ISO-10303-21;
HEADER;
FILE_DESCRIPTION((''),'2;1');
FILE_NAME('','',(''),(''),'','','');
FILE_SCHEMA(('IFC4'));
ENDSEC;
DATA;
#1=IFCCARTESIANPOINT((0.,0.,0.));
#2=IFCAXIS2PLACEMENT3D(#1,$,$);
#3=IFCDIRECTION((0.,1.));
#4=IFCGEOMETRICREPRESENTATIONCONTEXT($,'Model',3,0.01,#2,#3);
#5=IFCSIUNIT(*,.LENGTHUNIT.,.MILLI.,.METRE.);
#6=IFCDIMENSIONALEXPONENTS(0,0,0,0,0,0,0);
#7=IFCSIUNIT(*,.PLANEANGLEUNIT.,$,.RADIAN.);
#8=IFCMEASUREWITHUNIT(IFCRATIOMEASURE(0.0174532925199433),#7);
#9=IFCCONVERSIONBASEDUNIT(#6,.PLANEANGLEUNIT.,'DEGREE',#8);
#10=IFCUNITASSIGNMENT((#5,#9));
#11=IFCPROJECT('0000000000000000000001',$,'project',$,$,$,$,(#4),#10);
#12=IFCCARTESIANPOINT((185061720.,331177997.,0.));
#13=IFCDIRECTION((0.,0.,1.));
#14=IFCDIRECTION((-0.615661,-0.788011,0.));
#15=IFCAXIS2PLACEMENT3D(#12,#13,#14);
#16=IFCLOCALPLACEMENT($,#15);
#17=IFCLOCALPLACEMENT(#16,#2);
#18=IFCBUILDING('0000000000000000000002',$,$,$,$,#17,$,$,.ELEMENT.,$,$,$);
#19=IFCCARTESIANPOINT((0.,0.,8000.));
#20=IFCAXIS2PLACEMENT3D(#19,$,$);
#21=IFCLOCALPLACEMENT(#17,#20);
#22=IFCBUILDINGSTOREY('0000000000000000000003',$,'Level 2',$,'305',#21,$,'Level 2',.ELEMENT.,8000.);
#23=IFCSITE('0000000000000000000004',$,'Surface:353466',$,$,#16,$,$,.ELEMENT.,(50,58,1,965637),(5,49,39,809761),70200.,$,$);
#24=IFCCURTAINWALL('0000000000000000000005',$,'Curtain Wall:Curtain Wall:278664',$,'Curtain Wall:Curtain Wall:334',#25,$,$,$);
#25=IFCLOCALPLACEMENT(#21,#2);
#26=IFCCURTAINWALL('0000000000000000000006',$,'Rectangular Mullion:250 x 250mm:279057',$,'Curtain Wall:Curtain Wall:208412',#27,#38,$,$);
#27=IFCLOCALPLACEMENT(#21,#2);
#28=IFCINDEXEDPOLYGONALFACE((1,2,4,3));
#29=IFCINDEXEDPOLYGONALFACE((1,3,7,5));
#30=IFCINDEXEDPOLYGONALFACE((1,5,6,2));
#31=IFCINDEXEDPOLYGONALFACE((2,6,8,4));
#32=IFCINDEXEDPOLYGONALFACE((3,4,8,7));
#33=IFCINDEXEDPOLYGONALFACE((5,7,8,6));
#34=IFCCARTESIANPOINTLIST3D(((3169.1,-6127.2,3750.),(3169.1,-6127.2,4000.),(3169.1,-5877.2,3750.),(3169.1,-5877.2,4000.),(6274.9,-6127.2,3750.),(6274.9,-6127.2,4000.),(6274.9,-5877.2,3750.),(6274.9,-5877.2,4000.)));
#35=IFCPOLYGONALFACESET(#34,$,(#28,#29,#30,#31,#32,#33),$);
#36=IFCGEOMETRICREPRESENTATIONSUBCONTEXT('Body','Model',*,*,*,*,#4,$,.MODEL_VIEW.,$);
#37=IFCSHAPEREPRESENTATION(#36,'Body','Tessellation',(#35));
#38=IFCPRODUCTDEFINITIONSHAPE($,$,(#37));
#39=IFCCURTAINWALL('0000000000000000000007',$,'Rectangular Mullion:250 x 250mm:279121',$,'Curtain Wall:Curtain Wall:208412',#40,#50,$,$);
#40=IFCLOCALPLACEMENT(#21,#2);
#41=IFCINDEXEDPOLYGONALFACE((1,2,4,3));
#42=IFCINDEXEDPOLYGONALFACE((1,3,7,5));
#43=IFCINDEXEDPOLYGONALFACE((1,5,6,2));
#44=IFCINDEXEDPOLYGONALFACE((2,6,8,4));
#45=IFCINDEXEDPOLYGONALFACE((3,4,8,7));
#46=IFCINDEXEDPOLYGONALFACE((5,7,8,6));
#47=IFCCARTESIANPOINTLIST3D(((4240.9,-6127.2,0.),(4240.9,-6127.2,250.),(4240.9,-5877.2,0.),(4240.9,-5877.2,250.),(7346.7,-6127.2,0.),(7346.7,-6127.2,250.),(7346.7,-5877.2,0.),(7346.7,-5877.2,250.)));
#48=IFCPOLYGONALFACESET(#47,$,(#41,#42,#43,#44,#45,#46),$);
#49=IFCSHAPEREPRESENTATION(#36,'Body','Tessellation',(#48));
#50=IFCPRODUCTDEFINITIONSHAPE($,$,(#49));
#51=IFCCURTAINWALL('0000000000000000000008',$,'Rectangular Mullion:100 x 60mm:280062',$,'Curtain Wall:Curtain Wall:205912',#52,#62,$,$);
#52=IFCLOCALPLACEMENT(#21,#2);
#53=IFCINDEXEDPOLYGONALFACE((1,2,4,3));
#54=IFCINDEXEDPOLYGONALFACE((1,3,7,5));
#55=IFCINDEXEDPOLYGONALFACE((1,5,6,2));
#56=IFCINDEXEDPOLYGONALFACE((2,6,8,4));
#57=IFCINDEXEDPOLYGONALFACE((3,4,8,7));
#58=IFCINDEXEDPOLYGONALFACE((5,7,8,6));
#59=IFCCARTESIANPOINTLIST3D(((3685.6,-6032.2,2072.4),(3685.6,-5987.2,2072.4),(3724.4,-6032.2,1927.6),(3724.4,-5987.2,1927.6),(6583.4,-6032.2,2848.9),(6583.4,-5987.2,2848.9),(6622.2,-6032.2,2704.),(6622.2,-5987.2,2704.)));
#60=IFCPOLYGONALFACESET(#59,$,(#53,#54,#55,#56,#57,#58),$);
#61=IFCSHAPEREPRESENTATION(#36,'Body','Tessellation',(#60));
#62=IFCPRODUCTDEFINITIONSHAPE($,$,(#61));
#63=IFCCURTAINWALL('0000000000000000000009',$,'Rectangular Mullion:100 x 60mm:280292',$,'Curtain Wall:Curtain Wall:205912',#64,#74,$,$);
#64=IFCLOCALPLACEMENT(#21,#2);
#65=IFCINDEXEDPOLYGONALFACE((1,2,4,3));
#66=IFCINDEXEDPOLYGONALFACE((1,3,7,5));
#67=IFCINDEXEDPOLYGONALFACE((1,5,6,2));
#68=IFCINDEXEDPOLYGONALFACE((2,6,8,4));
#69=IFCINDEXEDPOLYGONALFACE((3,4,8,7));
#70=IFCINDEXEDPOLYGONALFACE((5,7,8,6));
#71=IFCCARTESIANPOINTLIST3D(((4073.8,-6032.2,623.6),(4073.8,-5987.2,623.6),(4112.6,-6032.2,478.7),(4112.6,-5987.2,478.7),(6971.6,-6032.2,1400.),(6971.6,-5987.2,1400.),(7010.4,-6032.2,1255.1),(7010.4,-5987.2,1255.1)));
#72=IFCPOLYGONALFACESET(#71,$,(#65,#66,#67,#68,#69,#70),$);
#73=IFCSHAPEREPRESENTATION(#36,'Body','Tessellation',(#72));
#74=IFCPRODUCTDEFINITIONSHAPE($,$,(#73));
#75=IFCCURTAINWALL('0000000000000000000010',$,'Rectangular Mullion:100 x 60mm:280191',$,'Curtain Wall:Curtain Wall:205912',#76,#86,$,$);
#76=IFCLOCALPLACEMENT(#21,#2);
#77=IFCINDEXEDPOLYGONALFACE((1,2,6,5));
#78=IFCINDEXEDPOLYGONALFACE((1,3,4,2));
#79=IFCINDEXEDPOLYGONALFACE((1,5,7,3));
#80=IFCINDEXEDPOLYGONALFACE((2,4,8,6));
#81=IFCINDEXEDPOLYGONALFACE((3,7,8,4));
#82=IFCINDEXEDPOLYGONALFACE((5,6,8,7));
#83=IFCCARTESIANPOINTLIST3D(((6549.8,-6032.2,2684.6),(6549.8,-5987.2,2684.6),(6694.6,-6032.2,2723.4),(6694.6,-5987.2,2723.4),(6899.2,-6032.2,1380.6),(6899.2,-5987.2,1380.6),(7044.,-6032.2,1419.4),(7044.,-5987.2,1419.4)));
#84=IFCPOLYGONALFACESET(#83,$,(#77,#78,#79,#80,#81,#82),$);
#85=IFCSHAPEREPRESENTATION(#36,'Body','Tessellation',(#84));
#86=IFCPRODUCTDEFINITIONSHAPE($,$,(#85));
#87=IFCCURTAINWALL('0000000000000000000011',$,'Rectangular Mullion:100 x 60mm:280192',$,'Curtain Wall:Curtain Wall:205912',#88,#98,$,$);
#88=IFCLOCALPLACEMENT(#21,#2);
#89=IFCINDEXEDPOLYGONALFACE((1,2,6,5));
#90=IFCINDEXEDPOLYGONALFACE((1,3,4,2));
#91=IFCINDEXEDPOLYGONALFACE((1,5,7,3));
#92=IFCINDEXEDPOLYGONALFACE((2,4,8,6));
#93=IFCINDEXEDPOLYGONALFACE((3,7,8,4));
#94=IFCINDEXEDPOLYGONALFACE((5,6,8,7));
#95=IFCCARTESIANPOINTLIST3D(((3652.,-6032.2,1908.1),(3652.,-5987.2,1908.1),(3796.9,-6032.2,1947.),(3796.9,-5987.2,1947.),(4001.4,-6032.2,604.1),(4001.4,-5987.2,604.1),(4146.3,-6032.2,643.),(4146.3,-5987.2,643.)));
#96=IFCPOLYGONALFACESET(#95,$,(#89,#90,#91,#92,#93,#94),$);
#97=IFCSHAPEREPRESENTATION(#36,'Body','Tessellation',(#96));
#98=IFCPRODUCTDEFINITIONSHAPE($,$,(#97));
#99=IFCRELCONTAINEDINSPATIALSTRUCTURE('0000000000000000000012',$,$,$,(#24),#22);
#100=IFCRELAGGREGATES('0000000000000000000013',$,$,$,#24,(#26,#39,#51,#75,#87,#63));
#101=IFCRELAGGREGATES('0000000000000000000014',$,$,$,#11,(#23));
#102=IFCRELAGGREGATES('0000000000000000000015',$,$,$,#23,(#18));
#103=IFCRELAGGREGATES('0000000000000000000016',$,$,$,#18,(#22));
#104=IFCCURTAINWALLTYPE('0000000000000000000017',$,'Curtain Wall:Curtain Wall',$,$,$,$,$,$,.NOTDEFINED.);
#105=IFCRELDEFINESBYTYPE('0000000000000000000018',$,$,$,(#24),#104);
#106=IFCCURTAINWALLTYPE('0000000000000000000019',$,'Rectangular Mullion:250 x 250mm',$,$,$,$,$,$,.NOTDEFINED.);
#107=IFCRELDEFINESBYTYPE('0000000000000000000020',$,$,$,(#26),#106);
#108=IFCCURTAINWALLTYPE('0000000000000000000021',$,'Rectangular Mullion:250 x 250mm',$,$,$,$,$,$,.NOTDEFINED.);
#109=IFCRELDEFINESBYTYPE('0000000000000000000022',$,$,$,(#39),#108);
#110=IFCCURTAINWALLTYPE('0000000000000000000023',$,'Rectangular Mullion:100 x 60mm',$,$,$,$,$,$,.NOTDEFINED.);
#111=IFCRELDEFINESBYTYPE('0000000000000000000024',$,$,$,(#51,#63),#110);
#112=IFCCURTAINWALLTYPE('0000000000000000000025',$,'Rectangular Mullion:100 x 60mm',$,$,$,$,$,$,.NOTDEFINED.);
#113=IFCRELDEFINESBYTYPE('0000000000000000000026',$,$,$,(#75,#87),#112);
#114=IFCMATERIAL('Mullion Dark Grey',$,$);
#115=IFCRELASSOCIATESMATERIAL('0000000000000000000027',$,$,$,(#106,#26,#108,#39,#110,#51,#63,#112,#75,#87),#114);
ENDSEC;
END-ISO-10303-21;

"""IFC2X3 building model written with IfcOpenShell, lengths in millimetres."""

from ifc_helpers import new_model, entity, si_unit, converted_unit, direction, frame, frame_2d, origin, origin_2d_with_axis, place, context, subcontext, project, spatial, rectangle, extrude, source, transform, mapped, material, type_object, type_shapes, element, aggregate, save


model = new_model("IFC2X3")

# Units and contexts
model_context = context("Model", 3, precision=0.01, world=origin(), true_north=direction((0.0, 1.0)))
body_context = subcontext(model_context, "Body", "Model", "MODEL_VIEW")
ifc_project = project(units=[si_unit("LENGTHUNIT", "METRE", prefix="MILLI"), converted_unit("PLANEANGLEUNIT", "DEGREE", entity("IfcRatioMeasure", 0.0174532925199433), si_unit("PLANEANGLEUNIT", "RADIAN"), dimensions=[0, 0, 0, 0, 0, 0, 0])], contexts=[model_context])

# Site, building, storey
site_placement = place(None, frame((185061720.0, 331177997.0, 0.0), z_axis=(0.0, 0.0, 1.0), x_axis=(-0.615661, -0.788011, 0.0)))
site = spatial("IfcSite", under=ifc_project, at=site_placement, Name="Surface:353466", CompositionType="ELEMENT", RefLatitude=(50, 58, 1, 965637), RefLongitude=(5, 49, 39, 809761), RefElevation=70200.0)
building_placement = place(site_placement, origin())
building = spatial("IfcBuilding", under=site, at=building_placement, CompositionType="ELEMENT")
storey_placement = place(building_placement, frame((0.0, 0.0, 8000.0)))
storey = spatial("IfcBuildingStorey", under=building, at=storey_placement, Name="Level 2", ObjectType="305", LongName="Level 2", CompositionType="ELEMENT", Elevation=8000.0)

# Curtain walls
curtain_wall_type_1 = type_object("IfcCurtainWallType", Name="Curtain Wall:Curtain Wall", PredefinedType="NOTDEFINED")
curtain_wall_1_placement = place(storey_placement, frame((0.0, 0.0, -8000.0)))
curtain_wall_1 = element("IfcCurtainWall", 1, at=curtain_wall_1_placement, inside=storey, type_object=curtain_wall_type_1, Name="Curtain Wall:Curtain Wall:278664", ObjectType="Curtain Wall:Curtain Wall:334")
ifc_material_1 = material(Name="Mullion Dark Grey")
curtain_wall_type_2 = type_object("IfcCurtainWallType", Name="Rectangular Mullion:250 x 250mm", PredefinedType="NOTDEFINED", material=ifc_material_1)
shared_shape_1 = source(origin(), body_context, "Body", "SweptSolid", [
    extrude(rectangle(XDim=250.0, YDim=250.0, at=origin_2d_with_axis()), frame((-125.0, 0.0, -3105.8), z_axis=(0.0, 0.0, 1.0), x_axis=(-1.0, 0.0, 0.0)), (0.0, 0.0, 1.0), 3105.8),
])
type_shapes(curtain_wall_type_2, [shared_shape_1])
curtain_wall_2_placement = place(storey_placement, frame((6274.9, -6002.2, 4000.0), z_axis=(1.0, 0.0, 0.0), x_axis=(0.0, 0.0, 1.0)))
curtain_wall_2 = element("IfcCurtainWall", 2, at=curtain_wall_2_placement, type_object=curtain_wall_type_2, material=ifc_material_1, Name="Rectangular Mullion:250 x 250mm:279057", ObjectType="Curtain Wall:Curtain Wall:208412", context=body_context, shape_type="MappedRepresentation", body=[
    mapped(shared_shape_1, transform((0.0, 0.0, 0.0), scale=1.0)),
])
curtain_wall_type_3 = type_object("IfcCurtainWallType", Name="Rectangular Mullion:250 x 250mm", PredefinedType="NOTDEFINED", material=ifc_material_1)
shared_shape_2 = source(origin(), body_context, "Body", "SweptSolid", [
    extrude(rectangle(XDim=250.0, YDim=250.0, at=origin_2d_with_axis()), frame((-125.0, 0.0, -3105.8), z_axis=(0.0, 0.0, 1.0), x_axis=(-1.0, 0.0, 0.0)), (0.0, 0.0, 1.0), 3105.8),
])
type_shapes(curtain_wall_type_3, [shared_shape_2])
curtain_wall_3_placement = place(storey_placement, frame((4240.9, -6002.2, 0.0), z_axis=(-1.0, 0.0, 0.0), x_axis=(0.0, 0.0, -1.0)))
curtain_wall_3 = element("IfcCurtainWall", 3, at=curtain_wall_3_placement, type_object=curtain_wall_type_3, material=ifc_material_1, Name="Rectangular Mullion:250 x 250mm:279121", ObjectType="Curtain Wall:Curtain Wall:208412", context=body_context, shape_type="MappedRepresentation", body=[
    mapped(shared_shape_2, transform((0.0, 0.0, 0.0), scale=1.0)),
])
curtain_wall_type_4 = type_object("IfcCurtainWallType", Name="Rectangular Mullion:100 x 60mm", PredefinedType="NOTDEFINED", material=ifc_material_1)
shared_shape_3 = source(origin(), body_context, "Body", "SweptSolid", [
    extrude(rectangle(XDim=45.0, YDim=150.0, at=frame_2d((0.0, 0.0), x_axis=(1.0, 0.0))), frame((0.0, 7.5, -3000.0), z_axis=(0.0, 0.0, 1.0), x_axis=(0.0, -1.0, 0.0)), (0.0, 0.0, 1.0), 3000.0),
])
type_shapes(curtain_wall_type_4, [shared_shape_3])
curtain_wall_4_placement = place(storey_placement, frame((6602.8, -6002.2, 2776.5), z_axis=(0.965926, 0.0, 0.258819), x_axis=(-0.258819, 0.0, 0.965926)))
curtain_wall_4 = element("IfcCurtainWall", 4, at=curtain_wall_4_placement, type_object=curtain_wall_type_4, material=ifc_material_1, Name="Rectangular Mullion:100 x 60mm:280062", ObjectType="Curtain Wall:Curtain Wall:205912", context=body_context, shape_type="MappedRepresentation", body=[
    mapped(shared_shape_3, transform((0.0, 0.0, 0.0), scale=1.0)),
])
curtain_wall_5_placement = place(storey_placement, frame((6991.0, -6002.2, 1327.6), z_axis=(0.965926, 0.0, 0.258819), x_axis=(-0.258819, 0.0, 0.965926)))
curtain_wall_5 = element("IfcCurtainWall", 5, at=curtain_wall_5_placement, type_object=curtain_wall_type_4, material=ifc_material_1, Name="Rectangular Mullion:100 x 60mm:280292", ObjectType="Curtain Wall:Curtain Wall:205912", context=body_context, shape_type="MappedRepresentation", body=[
    mapped(shared_shape_3, transform((0.0, 0.0, 0.0), scale=1.0)),
])
curtain_wall_type_5 = type_object("IfcCurtainWallType", Name="Rectangular Mullion:100 x 60mm", PredefinedType="NOTDEFINED", material=ifc_material_1)
shared_shape_4 = source(origin(), body_context, "Body", "SweptSolid", [
    extrude(rectangle(XDim=45.0, YDim=150.0, at=frame_2d((0.0, 0.0), x_axis=(1.0, 0.0))), frame((0.0, 7.5, -1350.0), z_axis=(0.0, 0.0, 1.0), x_axis=(0.0, -1.0, 0.0)), (0.0, 0.0, 1.0), 1350.0),
])
type_shapes(curtain_wall_type_5, [shared_shape_4])
curtain_wall_6_placement = place(storey_placement, frame((6971.6, -6002.2, 1400.0), z_axis=(0.258819, 0.0, -0.965926), x_axis=(0.965926, 0.0, 0.258819)))
curtain_wall_6 = element("IfcCurtainWall", 6, at=curtain_wall_6_placement, type_object=curtain_wall_type_5, material=ifc_material_1, Name="Rectangular Mullion:100 x 60mm:280191", ObjectType="Curtain Wall:Curtain Wall:205912", context=body_context, shape_type="MappedRepresentation", body=[
    mapped(shared_shape_4, transform((0.0, 0.0, 0.0), scale=1.0)),
])
curtain_wall_7_placement = place(storey_placement, frame((4073.8, -6002.2, 623.6), z_axis=(0.258819, 0.0, -0.965926), x_axis=(0.965926, 0.0, 0.258819)))
curtain_wall_7 = element("IfcCurtainWall", 7, at=curtain_wall_7_placement, type_object=curtain_wall_type_5, material=ifc_material_1, Name="Rectangular Mullion:100 x 60mm:280192", ObjectType="Curtain Wall:Curtain Wall:205912", context=body_context, shape_type="MappedRepresentation", body=[
    mapped(shared_shape_4, transform((0.0, 0.0, 0.0), scale=1.0)),
])
aggregate(curtain_wall_1, [curtain_wall_2, curtain_wall_3, curtain_wall_4, curtain_wall_6, curtain_wall_7, curtain_wall_5])

save(model, "model.ifc")
